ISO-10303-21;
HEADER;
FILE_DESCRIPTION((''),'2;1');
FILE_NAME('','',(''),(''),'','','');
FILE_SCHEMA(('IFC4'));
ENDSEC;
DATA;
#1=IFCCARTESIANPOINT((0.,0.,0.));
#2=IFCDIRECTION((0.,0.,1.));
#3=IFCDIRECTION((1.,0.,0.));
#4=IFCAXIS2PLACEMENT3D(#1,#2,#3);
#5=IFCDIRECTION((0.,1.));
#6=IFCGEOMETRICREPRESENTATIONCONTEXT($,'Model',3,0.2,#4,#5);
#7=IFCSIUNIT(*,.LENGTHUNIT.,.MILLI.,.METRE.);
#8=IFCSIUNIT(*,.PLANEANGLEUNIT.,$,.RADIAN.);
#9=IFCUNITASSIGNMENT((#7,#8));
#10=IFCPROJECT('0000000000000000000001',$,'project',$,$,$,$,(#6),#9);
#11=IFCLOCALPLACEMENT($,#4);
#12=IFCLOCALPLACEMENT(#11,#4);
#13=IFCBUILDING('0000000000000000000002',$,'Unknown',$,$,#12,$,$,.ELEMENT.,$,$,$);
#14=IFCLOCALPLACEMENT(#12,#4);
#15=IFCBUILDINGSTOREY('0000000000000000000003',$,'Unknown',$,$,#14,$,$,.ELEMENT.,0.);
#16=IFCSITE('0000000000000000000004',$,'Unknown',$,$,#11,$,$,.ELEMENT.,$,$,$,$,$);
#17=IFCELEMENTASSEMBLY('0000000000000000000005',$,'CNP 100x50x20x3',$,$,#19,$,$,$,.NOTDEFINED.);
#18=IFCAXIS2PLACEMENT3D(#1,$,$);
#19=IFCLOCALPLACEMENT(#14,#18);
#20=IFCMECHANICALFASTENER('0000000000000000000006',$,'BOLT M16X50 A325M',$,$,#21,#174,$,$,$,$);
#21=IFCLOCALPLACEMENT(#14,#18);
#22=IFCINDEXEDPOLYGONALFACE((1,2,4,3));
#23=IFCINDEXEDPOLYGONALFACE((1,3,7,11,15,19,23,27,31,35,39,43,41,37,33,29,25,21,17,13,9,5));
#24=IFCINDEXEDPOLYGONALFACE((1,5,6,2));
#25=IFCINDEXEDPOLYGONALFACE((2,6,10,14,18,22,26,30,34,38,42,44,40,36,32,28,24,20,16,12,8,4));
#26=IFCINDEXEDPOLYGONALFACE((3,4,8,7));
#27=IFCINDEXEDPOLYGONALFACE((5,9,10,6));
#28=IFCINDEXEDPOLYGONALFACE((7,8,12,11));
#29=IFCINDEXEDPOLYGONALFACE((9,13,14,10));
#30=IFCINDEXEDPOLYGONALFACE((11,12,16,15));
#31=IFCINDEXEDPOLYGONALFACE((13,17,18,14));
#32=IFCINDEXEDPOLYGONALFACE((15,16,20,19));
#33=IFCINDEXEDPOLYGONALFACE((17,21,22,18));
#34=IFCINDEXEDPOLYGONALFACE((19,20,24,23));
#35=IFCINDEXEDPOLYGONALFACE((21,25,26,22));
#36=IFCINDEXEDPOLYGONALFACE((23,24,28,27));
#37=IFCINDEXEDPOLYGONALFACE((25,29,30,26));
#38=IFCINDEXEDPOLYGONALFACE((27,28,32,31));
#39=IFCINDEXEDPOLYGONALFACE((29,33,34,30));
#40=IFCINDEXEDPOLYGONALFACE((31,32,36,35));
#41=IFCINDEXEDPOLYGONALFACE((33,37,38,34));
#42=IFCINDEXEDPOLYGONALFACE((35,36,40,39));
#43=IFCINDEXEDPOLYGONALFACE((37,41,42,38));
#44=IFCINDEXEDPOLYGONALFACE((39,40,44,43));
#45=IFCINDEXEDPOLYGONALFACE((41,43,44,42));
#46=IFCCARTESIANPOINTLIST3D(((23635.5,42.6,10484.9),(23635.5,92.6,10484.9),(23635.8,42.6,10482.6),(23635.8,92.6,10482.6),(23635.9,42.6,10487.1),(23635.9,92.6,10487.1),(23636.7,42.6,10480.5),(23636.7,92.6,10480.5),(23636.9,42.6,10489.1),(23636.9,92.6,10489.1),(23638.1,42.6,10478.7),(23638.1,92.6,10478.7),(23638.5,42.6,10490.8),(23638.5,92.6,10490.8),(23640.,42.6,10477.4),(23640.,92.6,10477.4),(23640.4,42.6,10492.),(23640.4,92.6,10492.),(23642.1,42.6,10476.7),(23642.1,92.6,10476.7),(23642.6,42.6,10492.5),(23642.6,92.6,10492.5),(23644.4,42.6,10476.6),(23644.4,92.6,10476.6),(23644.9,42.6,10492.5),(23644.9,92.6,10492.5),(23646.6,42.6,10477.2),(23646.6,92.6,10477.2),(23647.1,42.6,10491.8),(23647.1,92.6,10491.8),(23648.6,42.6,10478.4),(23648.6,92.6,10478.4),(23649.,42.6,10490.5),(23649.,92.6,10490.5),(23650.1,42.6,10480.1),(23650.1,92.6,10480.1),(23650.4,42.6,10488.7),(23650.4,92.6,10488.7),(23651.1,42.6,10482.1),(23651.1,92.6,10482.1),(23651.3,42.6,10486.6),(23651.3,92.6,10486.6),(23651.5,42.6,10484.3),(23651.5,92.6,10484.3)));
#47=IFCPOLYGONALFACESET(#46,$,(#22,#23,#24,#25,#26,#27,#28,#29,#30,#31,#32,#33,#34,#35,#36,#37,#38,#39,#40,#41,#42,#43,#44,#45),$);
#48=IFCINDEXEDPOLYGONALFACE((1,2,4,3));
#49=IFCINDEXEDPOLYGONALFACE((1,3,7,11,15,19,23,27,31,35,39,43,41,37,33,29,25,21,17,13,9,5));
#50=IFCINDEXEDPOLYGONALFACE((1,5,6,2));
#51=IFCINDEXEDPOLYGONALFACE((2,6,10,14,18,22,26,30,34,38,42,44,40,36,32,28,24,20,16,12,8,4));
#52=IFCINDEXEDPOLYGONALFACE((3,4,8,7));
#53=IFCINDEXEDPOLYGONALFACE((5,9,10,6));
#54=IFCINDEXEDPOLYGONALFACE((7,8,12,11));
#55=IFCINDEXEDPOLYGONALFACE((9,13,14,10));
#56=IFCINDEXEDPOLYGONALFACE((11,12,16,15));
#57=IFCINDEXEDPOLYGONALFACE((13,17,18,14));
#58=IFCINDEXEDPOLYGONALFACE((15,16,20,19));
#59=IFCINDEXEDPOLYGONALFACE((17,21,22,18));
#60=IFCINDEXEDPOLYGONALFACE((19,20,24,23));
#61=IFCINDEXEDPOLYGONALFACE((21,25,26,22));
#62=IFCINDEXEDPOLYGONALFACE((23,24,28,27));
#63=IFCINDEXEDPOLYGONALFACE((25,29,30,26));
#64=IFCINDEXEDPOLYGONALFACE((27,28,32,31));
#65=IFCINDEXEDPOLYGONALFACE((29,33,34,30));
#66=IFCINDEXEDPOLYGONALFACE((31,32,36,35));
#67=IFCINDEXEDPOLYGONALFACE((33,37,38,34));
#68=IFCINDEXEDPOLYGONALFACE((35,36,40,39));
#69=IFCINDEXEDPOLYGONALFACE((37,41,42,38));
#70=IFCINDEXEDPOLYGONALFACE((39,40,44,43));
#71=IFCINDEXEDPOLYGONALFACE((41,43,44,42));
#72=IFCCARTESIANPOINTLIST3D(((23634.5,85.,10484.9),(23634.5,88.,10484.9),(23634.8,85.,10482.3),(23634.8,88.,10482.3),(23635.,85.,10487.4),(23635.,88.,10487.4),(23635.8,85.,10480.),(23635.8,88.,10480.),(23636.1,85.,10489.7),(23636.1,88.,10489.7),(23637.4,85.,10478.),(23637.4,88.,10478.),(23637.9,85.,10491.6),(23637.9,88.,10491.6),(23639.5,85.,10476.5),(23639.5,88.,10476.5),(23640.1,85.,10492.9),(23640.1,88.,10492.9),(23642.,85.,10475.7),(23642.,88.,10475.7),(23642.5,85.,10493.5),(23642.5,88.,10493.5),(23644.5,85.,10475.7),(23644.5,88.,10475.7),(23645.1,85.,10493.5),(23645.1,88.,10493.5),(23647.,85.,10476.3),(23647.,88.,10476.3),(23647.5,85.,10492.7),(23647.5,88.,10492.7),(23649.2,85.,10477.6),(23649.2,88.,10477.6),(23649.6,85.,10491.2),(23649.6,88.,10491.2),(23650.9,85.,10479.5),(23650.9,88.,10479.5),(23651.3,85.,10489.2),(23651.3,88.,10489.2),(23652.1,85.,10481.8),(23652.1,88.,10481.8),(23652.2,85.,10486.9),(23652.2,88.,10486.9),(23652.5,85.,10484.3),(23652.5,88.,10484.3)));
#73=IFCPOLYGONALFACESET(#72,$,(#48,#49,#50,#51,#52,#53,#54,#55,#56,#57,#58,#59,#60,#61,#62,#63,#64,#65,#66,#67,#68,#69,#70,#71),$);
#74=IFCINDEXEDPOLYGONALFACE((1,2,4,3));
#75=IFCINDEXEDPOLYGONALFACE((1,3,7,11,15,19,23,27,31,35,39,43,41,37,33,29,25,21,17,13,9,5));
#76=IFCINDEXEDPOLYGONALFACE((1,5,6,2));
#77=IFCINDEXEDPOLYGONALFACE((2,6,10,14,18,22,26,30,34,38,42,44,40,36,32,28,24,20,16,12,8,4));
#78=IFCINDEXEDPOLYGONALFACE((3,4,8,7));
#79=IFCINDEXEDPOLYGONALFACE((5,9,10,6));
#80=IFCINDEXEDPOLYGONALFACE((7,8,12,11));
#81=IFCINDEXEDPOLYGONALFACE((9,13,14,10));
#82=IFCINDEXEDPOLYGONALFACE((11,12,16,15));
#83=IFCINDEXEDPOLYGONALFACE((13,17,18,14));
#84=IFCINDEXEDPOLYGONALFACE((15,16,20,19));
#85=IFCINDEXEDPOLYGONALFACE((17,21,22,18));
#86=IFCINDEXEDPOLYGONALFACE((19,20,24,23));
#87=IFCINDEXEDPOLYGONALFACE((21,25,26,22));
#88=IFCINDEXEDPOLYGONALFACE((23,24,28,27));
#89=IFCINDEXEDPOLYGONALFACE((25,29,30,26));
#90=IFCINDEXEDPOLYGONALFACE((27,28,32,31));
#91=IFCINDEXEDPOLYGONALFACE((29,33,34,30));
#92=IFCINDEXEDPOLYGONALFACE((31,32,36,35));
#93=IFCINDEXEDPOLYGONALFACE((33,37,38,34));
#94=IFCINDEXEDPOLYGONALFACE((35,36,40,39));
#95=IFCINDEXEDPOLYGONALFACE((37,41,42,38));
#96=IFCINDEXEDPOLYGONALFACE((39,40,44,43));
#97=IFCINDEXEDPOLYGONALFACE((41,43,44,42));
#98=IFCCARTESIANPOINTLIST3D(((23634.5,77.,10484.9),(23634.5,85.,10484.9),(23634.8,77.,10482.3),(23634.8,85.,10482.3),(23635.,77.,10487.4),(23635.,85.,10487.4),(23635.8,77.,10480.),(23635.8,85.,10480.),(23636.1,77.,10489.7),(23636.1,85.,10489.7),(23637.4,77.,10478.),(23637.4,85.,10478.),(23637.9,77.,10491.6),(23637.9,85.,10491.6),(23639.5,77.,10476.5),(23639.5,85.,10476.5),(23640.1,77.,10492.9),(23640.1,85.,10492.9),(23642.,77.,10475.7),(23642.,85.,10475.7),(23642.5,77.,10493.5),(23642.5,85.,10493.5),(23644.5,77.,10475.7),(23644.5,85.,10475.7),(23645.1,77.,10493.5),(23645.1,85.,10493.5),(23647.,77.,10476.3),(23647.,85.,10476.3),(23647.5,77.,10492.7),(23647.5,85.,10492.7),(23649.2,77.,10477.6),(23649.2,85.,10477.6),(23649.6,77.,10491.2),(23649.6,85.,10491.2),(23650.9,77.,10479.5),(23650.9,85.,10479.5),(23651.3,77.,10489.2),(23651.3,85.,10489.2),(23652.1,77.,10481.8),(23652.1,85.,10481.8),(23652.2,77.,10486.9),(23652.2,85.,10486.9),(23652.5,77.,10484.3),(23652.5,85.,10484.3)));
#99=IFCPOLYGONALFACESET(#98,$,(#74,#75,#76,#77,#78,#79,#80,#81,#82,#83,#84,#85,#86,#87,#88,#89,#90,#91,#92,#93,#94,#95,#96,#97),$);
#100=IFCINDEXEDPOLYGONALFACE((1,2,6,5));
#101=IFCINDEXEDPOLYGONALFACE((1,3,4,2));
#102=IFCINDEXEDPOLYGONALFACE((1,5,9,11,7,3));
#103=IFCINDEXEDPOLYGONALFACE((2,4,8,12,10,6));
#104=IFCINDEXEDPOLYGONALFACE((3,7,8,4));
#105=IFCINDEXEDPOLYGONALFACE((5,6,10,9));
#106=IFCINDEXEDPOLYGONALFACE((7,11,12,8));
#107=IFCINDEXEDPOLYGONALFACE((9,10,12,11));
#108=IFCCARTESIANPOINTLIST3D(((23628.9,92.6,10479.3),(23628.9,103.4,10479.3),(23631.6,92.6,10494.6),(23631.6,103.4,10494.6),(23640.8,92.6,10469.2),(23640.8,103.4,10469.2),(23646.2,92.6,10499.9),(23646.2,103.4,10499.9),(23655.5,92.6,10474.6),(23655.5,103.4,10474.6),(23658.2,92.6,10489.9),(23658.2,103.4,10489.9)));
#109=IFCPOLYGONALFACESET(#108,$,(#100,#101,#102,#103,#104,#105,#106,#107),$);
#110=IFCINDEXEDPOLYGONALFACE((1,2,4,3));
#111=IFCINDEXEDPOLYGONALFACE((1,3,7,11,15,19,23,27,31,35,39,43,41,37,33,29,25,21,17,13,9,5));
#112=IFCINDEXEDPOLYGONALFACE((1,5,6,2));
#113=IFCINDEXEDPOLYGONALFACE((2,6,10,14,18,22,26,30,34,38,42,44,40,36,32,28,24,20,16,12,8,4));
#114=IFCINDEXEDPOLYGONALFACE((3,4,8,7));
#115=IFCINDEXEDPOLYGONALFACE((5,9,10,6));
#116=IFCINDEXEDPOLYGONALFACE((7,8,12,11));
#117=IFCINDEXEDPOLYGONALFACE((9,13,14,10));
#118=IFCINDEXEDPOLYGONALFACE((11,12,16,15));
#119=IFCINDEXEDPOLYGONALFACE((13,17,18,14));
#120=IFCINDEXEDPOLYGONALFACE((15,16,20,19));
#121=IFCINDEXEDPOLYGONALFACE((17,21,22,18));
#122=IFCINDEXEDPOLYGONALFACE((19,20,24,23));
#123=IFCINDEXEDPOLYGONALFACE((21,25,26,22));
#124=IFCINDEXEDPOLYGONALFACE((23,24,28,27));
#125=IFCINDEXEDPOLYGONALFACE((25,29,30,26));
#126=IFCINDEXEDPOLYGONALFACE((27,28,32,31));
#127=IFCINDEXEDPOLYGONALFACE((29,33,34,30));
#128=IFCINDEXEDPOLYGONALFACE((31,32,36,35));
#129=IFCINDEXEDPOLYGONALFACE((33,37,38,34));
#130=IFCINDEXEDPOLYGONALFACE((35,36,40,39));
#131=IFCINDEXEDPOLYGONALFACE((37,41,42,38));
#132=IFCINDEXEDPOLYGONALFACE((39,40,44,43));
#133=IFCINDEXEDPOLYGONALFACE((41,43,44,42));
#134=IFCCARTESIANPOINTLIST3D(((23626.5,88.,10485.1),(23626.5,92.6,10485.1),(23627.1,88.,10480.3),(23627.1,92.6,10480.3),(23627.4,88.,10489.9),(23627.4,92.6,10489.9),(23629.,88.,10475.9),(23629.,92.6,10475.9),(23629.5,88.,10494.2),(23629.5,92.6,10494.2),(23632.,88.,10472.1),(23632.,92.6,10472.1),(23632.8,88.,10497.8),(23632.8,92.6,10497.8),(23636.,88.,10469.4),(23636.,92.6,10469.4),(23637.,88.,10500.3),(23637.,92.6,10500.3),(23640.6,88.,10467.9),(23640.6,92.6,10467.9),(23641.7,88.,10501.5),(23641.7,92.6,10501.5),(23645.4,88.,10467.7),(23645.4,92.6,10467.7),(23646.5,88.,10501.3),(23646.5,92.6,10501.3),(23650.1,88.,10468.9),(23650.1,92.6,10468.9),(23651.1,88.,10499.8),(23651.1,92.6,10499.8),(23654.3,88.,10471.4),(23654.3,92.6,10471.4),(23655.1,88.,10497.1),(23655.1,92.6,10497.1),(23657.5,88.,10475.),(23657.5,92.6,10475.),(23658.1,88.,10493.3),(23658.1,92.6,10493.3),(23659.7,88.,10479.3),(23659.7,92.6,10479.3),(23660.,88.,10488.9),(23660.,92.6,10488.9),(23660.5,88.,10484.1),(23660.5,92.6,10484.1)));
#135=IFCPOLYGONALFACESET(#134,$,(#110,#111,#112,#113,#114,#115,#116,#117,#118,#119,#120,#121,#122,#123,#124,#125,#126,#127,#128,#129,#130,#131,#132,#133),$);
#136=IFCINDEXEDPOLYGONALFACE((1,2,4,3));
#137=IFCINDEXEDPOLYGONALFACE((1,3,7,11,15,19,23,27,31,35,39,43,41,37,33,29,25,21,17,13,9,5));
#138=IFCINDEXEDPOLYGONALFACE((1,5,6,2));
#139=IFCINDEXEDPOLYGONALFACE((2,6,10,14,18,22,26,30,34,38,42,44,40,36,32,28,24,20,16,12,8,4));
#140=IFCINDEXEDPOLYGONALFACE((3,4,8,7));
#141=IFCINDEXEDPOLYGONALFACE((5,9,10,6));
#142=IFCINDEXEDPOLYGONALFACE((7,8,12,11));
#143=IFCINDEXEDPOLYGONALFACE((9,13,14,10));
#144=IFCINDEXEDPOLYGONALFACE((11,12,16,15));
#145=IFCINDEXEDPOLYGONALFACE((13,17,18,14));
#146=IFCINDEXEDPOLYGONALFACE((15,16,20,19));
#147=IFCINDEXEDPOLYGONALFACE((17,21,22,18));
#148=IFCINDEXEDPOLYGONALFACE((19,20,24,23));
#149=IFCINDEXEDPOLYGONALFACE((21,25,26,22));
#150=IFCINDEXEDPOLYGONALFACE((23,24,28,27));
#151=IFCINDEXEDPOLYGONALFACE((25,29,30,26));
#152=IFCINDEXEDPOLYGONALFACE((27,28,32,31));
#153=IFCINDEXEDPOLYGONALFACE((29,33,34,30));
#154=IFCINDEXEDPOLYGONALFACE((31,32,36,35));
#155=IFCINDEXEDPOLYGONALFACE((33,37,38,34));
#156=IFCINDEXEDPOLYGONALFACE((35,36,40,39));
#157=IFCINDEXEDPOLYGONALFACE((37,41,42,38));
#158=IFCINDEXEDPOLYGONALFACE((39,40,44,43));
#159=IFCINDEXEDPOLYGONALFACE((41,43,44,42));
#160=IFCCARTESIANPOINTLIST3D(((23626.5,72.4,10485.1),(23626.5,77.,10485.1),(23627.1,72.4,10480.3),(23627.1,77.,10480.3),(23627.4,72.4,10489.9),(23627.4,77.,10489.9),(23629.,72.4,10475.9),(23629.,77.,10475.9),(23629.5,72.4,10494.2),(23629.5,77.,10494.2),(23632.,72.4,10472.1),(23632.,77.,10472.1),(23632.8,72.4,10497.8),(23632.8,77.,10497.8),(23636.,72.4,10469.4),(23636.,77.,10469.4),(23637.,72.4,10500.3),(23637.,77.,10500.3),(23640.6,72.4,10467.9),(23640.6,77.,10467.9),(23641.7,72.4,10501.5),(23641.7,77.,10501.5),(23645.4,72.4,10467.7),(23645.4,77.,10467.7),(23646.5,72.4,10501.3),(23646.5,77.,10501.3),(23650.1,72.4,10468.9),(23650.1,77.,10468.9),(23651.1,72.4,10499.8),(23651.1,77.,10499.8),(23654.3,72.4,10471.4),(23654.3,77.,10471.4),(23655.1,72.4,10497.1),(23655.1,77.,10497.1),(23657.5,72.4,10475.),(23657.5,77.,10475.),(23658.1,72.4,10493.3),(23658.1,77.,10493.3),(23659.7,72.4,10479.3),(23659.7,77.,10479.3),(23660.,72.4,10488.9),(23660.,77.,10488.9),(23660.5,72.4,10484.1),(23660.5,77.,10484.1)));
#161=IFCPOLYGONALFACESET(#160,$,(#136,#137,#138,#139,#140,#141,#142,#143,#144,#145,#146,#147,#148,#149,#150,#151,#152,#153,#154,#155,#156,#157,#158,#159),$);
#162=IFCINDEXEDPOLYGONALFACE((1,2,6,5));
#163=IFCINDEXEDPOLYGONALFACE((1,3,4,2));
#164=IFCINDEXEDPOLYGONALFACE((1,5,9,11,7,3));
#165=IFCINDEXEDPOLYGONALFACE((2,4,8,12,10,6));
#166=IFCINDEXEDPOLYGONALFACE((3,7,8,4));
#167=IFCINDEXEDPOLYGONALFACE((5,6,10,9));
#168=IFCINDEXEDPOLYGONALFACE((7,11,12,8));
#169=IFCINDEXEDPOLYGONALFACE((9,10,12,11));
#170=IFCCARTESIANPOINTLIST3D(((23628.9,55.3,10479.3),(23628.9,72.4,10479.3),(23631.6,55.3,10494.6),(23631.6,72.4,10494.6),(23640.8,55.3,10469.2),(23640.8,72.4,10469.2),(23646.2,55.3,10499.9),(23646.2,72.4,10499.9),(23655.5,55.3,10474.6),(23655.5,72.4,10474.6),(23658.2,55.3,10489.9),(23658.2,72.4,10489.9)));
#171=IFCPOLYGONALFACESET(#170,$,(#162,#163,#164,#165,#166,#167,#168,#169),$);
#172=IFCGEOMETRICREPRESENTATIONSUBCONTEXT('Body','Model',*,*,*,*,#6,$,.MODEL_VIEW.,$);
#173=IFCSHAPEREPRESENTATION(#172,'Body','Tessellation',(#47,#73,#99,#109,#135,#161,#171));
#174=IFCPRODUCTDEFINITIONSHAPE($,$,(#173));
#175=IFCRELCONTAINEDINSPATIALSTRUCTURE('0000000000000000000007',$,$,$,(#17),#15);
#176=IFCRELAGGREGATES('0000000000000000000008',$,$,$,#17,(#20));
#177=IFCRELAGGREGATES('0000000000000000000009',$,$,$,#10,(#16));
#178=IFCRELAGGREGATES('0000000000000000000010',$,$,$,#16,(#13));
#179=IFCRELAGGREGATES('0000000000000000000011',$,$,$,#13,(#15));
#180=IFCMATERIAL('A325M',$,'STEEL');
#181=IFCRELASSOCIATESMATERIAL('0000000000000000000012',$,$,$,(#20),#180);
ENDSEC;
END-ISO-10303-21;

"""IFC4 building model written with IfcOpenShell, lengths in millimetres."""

from ifc_helpers import new_model, si_unit, direction, frame, origin_with_axes, place, context, subcontext, project, spatial, line, arc, indexed_curve, outline, extrude, source, transform, mapped, material, element, aggregate, save


model = new_model("IFC4")

# Units and contexts
model_context = context("Model", 3, precision=0.2, world=origin_with_axes(), true_north=direction((0.0, 1.0)))
body_context = subcontext(model_context, "Body", "Model", "MODEL_VIEW")
ifc_project = project(units=[si_unit("LENGTHUNIT", "METRE", prefix="MILLI"), si_unit("PLANEANGLEUNIT", "RADIAN")], contexts=[model_context])

# Site, building, storey
site_placement = place(None, origin_with_axes())
site = spatial("IfcSite", under=ifc_project, at=site_placement, Name="Unknown", CompositionType="ELEMENT")
building_placement = place(site_placement, origin_with_axes())
building = spatial("IfcBuilding", under=site, at=building_placement, Name="Unknown", CompositionType="ELEMENT")
storey_placement = place(building_placement, origin_with_axes())
storey = spatial("IfcBuildingStorey", under=building, at=storey_placement, Name="Unknown", CompositionType="ELEMENT", Elevation=0.0)

# Shared definitions
ifc_material_1 = material(Name="A325M", Category="STEEL")
shared_shape = source(origin_with_axes(), body_context, "Body", "SweptSolid", [
    extrude(outline(indexed_curve([(8.0, 0.0), (0.0, 8.0), (-8.0, 0.0), (0.0, -8.0)], segments=[arc(1, 2, 3), arc(3, 4, 1)])), frame((0.0, 0.0, 15.6), z_axis=(0.0, 0.0, -1.0), x_axis=(0.0, 1.0, 0.0)), (0.0, 0.0, 1.0), 50.0),
    extrude(outline(indexed_curve([(9.0, 0.0), (0.0, 9.0), (-9.0, 0.0), (0.0, -9.0)], segments=[arc(1, 2, 3), arc(3, 4, 1)])), frame((0.0, 0.0, 11.0), z_axis=(0.0, 0.0, -1.0), x_axis=(0.0, 1.0, 0.0)), (0.0, 0.0, 1.0), 3.0),
    extrude(outline(indexed_curve([(9.0, 0.0), (0.0, 9.0), (-9.0, 0.0), (0.0, -9.0)], segments=[arc(1, 2, 3), arc(3, 4, 1)])), frame((0.0, 0.0, 8.0), z_axis=(0.0, 0.0, -1.0), x_axis=(0.0, 1.0, 0.0)), (0.0, 0.0, 1.0), 8.0),
    extrude(outline(indexed_curve([(15.6, 0.0), (7.8, 13.5), (-7.8, 13.5), (-15.6, 0.0), (-7.8, -13.5), (7.8, -13.5)], segments=[line(1, 2, 3, 4, 5, 6, 1)])), frame((0.0, 0.0, 26.4), z_axis=(0.0, 0.0, -1.0), x_axis=(0.0, 1.0, 0.0)), (0.0, 0.0, 1.0), 10.8),
    extrude(outline(indexed_curve([(17.0, 0.0), (0.0, 17.0), (-17.0, 0.0), (0.0, -17.0)], segments=[arc(1, 2, 3), arc(3, 4, 1)])), frame((0.0, 0.0, 15.6), z_axis=(0.0, 0.0, -1.0), x_axis=(0.0, 1.0, 0.0)), (0.0, 0.0, 1.0), 4.6),
    extrude(outline(indexed_curve([(17.0, 0.0), (0.0, 17.0), (-17.0, 0.0), (0.0, -17.0)], segments=[arc(1, 2, 3), arc(3, 4, 1)])), frame((0.0, 0.0, 0.0), z_axis=(0.0, 0.0, -1.0), x_axis=(0.0, 1.0, 0.0)), (0.0, 0.0, 1.0), 4.6),
    extrude(outline(indexed_curve([(15.6, 0.0), (7.8, 13.5), (-7.8, 13.5), (-15.6, 0.0), (-7.8, -13.5), (7.8, -13.5)], segments=[line(1, 2, 3, 4, 5, 6, 1)])), frame((0.0, 0.0, -4.6), z_axis=(0.0, 0.0, -1.0), x_axis=(0.0, 1.0, 0.0)), (0.0, 0.0, 1.0), 17.1),
])

# Element assembly, mechanical fastener
assembly_1_placement = place(storey_placement, frame((25552.5, 110.0, 10153.1), z_axis=(0.173648, 0.0, 0.984808), x_axis=(-0.984808, 0.0, 0.173648)))
assembly_1 = element("IfcElementAssembly", 1, at=assembly_1_placement, inside=storey, Name="CNP 100x50x20x3", PredefinedType="NOTDEFINED")
mechanical_fastener_1_placement = place(assembly_1_placement, frame((1937.5, 33.0, -5.0), z_axis=(0.0, -1.0, 0.0), x_axis=(-1.0, 0.0, 0.0)))
mechanical_fastener_1 = element("IfcMechanicalFastener", 2, at=mechanical_fastener_1_placement, material=ifc_material_1, Name="BOLT M16X50 A325M", context=body_context, shape_type="MappedRepresentation", body=[
    mapped(shared_shape, transform((0.0, 0.0, 0.0))),
])
aggregate(assembly_1, [mechanical_fastener_1])

save(model, "model.ifc")
